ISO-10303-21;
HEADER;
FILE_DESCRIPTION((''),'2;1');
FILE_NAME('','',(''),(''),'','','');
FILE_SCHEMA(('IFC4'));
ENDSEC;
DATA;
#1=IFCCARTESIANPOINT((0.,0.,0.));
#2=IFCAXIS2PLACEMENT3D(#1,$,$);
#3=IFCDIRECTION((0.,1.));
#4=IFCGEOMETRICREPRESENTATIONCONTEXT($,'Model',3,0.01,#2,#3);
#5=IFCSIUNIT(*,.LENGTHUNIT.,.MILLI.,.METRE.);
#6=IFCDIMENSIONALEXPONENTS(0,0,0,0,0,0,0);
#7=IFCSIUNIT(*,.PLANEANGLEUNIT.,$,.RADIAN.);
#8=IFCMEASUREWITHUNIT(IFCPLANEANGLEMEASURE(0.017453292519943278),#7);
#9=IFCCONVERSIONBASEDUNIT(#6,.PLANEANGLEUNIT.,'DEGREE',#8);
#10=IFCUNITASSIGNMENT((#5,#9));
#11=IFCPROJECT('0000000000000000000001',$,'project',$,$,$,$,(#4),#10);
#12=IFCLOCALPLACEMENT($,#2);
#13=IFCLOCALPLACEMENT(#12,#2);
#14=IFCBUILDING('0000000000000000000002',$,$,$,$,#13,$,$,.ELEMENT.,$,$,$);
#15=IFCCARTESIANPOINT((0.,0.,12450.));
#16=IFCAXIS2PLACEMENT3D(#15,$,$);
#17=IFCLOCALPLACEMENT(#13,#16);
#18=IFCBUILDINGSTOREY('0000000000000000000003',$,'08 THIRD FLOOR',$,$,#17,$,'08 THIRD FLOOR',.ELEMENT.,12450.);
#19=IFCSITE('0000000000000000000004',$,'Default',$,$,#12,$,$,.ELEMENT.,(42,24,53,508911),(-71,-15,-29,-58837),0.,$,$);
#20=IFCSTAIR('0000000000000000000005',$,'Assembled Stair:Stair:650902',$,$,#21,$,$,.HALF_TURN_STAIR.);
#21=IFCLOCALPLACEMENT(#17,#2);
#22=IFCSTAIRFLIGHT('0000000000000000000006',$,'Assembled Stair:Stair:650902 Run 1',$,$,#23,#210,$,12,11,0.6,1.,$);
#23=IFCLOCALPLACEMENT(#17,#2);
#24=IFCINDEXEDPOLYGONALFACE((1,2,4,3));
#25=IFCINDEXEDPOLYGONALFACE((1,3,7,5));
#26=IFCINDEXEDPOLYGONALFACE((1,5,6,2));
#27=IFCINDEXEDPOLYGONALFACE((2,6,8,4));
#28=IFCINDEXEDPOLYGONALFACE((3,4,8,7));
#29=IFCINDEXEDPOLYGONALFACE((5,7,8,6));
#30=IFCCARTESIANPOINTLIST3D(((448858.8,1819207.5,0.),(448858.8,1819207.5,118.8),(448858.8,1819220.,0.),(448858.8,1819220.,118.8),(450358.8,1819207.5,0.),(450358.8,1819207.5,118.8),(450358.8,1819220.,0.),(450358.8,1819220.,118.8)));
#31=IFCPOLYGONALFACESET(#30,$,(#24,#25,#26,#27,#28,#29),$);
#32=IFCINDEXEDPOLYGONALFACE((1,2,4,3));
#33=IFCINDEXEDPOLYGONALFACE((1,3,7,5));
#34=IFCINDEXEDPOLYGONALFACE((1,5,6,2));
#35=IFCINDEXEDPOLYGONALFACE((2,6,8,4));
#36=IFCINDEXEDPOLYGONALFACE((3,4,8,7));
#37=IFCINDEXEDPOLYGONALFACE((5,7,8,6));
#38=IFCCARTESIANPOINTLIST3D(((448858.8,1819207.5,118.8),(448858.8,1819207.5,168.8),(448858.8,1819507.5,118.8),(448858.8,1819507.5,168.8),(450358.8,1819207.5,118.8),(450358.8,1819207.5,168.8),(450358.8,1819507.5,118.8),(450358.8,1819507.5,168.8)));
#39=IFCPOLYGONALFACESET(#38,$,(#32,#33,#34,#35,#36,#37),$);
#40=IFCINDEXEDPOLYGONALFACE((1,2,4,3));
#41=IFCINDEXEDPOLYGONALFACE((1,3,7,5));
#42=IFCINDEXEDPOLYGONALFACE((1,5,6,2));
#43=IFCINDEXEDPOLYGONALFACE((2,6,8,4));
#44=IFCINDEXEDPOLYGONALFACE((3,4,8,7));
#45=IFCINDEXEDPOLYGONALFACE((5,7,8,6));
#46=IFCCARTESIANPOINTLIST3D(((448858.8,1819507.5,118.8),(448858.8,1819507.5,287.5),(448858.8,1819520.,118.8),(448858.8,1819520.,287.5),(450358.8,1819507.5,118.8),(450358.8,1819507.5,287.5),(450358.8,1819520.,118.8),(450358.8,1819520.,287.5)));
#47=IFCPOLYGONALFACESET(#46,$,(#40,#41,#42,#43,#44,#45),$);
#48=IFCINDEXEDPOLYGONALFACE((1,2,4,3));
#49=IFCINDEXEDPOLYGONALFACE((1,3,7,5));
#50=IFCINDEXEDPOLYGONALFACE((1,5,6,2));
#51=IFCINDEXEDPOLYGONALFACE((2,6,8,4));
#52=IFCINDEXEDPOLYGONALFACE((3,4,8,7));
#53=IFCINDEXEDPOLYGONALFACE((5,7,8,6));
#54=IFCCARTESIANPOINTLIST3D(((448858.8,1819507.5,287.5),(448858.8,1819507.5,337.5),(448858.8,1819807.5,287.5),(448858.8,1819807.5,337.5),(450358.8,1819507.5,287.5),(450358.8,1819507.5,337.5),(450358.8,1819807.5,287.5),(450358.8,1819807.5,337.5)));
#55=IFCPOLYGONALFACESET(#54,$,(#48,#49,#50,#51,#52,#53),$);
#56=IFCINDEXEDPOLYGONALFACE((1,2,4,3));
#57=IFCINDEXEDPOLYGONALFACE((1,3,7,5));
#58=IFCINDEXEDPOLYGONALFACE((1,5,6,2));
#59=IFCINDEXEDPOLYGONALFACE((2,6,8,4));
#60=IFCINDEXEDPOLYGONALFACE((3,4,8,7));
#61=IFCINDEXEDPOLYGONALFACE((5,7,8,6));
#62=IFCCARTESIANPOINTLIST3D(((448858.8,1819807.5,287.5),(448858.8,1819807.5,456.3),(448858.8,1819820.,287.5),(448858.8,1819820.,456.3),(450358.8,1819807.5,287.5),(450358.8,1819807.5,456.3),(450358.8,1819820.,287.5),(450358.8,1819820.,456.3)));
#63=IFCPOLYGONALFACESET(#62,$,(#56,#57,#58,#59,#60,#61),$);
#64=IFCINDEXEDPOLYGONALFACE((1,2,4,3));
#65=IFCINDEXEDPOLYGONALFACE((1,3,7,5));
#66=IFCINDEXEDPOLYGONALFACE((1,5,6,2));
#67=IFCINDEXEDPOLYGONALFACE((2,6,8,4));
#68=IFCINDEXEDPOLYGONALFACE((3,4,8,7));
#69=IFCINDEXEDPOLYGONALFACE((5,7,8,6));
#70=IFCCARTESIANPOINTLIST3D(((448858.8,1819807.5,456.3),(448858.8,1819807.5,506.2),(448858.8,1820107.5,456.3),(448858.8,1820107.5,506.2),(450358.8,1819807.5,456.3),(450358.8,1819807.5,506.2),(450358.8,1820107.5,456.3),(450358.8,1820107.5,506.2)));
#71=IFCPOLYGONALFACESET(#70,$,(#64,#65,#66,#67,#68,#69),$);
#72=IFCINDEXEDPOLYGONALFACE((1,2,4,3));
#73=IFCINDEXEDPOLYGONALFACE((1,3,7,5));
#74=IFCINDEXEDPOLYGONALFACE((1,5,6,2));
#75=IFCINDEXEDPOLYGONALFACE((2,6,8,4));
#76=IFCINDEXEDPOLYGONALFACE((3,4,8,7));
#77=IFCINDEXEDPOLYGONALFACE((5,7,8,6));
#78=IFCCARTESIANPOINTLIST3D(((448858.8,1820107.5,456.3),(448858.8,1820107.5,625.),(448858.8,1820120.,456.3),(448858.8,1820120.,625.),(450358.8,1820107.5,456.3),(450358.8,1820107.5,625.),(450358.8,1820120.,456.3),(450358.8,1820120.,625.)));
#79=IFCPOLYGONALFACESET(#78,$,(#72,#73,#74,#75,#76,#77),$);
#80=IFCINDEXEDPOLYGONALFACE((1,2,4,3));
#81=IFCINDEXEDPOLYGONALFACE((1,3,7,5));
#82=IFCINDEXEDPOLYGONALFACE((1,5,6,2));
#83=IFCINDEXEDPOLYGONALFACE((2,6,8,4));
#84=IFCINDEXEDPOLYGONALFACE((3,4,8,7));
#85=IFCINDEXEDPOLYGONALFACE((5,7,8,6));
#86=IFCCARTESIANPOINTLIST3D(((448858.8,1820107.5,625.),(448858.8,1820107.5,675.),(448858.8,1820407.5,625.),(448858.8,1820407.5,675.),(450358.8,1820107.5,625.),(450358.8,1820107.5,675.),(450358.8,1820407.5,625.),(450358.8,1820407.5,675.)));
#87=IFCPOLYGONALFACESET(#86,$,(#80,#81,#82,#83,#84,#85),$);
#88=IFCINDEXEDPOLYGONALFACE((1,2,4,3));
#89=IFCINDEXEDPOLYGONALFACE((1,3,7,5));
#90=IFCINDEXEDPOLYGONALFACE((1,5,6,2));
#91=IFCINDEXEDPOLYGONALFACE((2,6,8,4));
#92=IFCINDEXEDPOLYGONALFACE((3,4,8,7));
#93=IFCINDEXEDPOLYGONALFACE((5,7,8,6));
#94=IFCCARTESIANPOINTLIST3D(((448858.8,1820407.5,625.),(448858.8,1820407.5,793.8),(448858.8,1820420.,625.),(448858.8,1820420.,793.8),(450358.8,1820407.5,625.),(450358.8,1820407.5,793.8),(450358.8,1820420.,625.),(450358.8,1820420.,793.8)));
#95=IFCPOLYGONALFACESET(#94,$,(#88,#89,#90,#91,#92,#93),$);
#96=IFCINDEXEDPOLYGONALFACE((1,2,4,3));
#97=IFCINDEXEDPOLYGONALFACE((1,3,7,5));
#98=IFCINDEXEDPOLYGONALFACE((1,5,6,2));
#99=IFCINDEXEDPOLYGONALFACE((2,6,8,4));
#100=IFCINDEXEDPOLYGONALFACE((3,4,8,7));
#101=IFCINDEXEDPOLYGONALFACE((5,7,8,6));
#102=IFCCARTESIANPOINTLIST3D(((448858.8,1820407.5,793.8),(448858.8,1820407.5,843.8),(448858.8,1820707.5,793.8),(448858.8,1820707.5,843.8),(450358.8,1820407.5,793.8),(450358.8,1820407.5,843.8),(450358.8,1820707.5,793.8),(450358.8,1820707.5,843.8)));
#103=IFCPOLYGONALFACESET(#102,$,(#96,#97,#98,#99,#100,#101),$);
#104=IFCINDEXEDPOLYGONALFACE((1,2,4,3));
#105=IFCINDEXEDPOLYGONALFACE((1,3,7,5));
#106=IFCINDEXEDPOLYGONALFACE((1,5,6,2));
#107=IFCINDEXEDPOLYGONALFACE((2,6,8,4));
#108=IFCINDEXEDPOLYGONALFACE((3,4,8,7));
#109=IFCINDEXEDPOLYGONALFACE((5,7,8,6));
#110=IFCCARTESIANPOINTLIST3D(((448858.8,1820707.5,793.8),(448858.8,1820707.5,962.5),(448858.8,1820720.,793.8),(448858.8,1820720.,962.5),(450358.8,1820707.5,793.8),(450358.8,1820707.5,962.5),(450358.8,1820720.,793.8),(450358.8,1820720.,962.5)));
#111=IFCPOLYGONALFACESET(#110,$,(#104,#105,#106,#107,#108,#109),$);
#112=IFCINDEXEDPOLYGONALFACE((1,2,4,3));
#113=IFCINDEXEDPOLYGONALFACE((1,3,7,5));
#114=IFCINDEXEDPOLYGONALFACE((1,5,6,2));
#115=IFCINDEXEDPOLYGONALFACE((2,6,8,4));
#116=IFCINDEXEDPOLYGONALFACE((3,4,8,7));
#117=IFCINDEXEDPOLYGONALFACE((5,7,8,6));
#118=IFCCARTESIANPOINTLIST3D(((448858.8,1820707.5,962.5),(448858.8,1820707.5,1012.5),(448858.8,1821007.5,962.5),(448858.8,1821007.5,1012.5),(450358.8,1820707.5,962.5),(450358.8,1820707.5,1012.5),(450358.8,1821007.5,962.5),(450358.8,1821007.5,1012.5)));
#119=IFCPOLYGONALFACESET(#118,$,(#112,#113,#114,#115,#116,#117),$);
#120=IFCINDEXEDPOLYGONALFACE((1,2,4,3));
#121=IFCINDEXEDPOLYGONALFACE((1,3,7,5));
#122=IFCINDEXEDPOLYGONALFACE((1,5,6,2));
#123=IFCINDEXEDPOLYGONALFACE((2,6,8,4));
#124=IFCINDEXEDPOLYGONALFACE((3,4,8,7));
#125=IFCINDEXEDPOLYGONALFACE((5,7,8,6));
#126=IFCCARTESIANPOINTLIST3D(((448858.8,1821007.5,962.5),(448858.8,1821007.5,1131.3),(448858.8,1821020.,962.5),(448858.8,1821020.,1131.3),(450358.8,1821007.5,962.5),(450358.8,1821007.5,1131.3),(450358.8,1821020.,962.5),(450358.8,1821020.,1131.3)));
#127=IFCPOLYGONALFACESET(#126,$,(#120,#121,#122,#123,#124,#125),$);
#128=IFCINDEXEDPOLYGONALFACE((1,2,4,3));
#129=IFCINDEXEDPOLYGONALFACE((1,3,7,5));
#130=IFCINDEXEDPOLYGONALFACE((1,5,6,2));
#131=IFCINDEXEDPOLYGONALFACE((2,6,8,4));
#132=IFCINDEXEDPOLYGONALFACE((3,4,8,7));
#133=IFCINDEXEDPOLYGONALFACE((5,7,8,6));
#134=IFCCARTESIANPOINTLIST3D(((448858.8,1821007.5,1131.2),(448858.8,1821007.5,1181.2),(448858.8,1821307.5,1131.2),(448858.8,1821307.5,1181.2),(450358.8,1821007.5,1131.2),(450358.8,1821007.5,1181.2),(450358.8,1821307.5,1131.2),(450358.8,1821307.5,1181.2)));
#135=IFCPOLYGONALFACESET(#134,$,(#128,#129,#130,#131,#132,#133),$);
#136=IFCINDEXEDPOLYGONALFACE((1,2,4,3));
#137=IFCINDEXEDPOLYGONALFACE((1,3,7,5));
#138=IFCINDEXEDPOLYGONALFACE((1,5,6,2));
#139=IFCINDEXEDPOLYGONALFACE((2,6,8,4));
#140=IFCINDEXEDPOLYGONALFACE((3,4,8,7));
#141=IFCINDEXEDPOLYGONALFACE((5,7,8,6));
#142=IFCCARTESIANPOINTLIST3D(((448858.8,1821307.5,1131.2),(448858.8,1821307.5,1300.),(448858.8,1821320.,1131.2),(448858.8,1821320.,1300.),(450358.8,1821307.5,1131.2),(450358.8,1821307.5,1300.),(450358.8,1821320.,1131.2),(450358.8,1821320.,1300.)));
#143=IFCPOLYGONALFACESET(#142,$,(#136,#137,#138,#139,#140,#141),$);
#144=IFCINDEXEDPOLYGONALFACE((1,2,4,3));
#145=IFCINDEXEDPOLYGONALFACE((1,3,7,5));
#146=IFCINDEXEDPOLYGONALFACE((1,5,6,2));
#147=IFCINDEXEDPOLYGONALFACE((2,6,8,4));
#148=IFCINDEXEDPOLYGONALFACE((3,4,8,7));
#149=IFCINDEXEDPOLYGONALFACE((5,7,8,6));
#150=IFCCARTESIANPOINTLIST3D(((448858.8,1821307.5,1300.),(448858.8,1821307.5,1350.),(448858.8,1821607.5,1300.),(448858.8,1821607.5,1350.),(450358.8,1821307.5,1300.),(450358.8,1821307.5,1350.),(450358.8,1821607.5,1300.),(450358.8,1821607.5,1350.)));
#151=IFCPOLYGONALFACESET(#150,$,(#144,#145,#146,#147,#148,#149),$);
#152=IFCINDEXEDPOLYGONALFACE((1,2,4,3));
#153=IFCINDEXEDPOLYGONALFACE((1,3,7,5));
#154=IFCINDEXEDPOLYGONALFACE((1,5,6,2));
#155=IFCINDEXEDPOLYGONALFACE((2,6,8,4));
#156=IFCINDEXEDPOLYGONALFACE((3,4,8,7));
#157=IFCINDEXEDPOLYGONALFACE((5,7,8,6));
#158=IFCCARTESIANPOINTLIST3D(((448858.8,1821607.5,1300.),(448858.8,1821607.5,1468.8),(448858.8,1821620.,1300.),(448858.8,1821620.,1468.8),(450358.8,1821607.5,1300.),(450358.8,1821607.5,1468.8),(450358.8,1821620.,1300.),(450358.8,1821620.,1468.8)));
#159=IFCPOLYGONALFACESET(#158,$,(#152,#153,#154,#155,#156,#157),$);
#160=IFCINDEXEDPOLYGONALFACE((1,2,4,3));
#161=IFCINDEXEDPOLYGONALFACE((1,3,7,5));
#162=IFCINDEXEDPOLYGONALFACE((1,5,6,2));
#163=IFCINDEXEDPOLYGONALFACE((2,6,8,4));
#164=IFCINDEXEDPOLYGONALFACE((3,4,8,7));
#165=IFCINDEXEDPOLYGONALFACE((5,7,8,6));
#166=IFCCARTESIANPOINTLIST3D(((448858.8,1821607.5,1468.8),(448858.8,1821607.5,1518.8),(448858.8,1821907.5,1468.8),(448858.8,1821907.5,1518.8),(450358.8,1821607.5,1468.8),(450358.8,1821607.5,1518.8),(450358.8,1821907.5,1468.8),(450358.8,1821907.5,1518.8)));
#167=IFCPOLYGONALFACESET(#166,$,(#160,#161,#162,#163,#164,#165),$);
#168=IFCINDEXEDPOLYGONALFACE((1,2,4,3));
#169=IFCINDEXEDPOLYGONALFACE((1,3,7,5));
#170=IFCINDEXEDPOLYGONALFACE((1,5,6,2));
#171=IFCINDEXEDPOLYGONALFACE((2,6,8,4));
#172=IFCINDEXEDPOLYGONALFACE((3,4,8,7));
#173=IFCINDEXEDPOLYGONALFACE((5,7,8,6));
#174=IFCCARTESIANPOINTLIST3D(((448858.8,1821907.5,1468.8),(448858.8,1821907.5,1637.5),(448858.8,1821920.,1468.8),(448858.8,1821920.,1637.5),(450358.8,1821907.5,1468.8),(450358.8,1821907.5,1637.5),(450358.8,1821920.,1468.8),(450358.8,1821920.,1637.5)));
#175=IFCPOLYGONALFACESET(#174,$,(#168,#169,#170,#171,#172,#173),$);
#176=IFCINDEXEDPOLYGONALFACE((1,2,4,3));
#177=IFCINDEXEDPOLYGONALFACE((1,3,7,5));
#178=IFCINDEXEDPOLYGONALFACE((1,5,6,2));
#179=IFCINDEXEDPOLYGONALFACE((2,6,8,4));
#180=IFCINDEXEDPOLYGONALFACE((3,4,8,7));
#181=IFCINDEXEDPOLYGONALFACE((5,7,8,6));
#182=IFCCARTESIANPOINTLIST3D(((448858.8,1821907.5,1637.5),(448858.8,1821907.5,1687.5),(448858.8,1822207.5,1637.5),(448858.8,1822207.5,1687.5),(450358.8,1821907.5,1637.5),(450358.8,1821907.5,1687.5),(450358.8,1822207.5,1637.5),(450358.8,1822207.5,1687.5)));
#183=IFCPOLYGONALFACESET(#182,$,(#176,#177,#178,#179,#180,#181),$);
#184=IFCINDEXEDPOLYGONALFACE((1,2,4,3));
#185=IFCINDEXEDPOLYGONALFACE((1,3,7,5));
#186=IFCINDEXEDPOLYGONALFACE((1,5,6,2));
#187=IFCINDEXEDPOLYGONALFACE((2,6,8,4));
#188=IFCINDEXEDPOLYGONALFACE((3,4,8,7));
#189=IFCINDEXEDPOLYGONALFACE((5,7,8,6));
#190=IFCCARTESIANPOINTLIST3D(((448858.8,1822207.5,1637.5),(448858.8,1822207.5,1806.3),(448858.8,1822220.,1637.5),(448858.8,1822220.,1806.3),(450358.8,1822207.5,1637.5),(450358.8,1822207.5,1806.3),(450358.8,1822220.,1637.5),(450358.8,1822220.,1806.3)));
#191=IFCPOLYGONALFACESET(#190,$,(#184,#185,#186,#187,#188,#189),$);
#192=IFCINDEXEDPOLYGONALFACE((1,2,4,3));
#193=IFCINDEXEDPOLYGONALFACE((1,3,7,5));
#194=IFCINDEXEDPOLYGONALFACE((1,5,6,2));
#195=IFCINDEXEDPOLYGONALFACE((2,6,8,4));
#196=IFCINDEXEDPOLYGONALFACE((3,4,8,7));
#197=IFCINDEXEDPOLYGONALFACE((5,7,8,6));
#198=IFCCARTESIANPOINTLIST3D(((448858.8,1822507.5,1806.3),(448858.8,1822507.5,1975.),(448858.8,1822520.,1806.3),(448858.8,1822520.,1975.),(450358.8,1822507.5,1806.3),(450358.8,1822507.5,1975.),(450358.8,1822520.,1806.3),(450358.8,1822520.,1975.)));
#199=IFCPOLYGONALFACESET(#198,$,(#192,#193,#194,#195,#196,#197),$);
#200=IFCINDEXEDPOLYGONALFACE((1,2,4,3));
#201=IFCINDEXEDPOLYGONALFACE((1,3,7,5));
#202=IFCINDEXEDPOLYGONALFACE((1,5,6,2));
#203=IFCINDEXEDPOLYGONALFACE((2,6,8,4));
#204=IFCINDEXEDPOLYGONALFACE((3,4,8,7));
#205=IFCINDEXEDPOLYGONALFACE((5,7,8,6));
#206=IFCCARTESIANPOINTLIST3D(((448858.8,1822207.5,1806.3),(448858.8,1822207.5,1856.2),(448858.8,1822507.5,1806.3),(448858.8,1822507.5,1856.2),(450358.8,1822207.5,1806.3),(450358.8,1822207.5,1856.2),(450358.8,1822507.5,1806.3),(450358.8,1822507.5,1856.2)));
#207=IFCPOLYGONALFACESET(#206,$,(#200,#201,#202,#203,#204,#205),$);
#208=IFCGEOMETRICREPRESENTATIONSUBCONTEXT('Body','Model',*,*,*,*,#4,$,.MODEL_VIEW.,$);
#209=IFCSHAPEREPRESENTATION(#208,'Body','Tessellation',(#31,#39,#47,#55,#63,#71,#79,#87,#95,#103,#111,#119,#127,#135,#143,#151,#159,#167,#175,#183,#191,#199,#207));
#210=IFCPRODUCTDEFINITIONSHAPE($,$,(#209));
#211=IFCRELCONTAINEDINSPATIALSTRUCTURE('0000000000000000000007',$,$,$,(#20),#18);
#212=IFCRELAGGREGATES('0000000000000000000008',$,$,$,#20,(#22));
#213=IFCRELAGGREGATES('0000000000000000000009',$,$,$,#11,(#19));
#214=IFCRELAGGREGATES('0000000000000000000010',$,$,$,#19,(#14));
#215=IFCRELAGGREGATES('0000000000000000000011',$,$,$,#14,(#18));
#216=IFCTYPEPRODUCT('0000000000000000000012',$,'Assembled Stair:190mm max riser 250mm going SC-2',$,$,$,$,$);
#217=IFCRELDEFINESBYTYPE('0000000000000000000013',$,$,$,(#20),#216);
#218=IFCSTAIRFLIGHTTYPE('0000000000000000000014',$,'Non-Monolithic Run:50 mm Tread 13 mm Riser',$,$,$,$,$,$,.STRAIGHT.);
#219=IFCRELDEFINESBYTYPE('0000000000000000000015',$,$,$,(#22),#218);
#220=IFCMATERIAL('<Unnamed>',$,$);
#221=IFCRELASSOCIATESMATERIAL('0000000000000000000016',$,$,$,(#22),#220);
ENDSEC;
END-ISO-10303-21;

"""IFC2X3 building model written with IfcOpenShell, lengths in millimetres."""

from ifc_helpers import new_model, entity, si_unit, converted_unit, direction, frame, frame_2d, origin, origin_2d_with_axis, place, context, subcontext, project, spatial, rectangle, extrude, material, type_object, element, aggregate, save


model = new_model("IFC2X3")

# Units and contexts
model_context = context("Model", 3, precision=0.01, world=origin(), true_north=direction((0.0, 1.0)))
body_context = subcontext(model_context, "Body", "Model", "MODEL_VIEW")
ifc_project = project(units=[si_unit("LENGTHUNIT", "METRE", prefix="MILLI"), converted_unit("PLANEANGLEUNIT", "DEGREE", entity("IfcPlaneAngleMeasure", 0.017453292519943278), si_unit("PLANEANGLEUNIT", "RADIAN"), dimensions=[0, 0, 0, 0, 0, 0, 0])], contexts=[model_context])

# Site, building, storey
site_placement = place(None, origin())
site = spatial("IfcSite", under=ifc_project, at=site_placement, Name="Default", CompositionType="ELEMENT", RefLatitude=(42, 24, 53, 508911), RefLongitude=(-71, -15, -29, -58837), RefElevation=0.0)
building_placement = place(site_placement, origin())
building = spatial("IfcBuilding", under=site, at=building_placement, CompositionType="ELEMENT")
storey_placement = place(building_placement, frame((0.0, 0.0, 12450.0)))
storey = spatial("IfcBuildingStorey", under=building, at=storey_placement, Name="08 THIRD FLOOR", LongName="08 THIRD FLOOR", CompositionType="ELEMENT", Elevation=12450.0)

# Stair
ifc_material_1 = material(Name="<Unnamed>")
type_product_1 = type_object("IfcTypeProduct", Name="Assembled Stair:190mm max riser 250mm going SC-2")
stair_1_placement = place(storey_placement, origin())
stair_1 = element("IfcStair", 1, at=stair_1_placement, inside=storey, type_object=type_product_1, Name="Assembled Stair:Stair:650902", ShapeType="HALF_TURN_STAIR")

# Stair flight
stair_flight_type = type_object("IfcStairFlightType", Name="Non-Monolithic Run:50 mm Tread 13 mm Riser", PredefinedType="STRAIGHT")
stair_flight_1_placement = place(stair_1_placement, origin())
stair_flight_1 = element("IfcStairFlight", 2, at=stair_flight_1_placement, type_object=stair_flight_type, material=ifc_material_1, Name="Assembled Stair:Stair:650902 Run 1", NumberOfRiser=12, NumberOfTreads=11, RiserHeight=0.6, TreadLength=1.0, context=body_context, shape_type="SweptSolid", body=[
    extrude(rectangle(XDim=1500.0, YDim=12.5, at=origin_2d_with_axis()), frame((449608.8, 1819213.8, 0.0), z_axis=(0.0, 0.0, 1.0), x_axis=(-1.0, 0.0, 0.0)), (0.0, 0.0, 1.0), 118.8),
    extrude(rectangle(XDim=300.0, YDim=1500.0, at=frame_2d((0.0, 0.0), x_axis=(1.0, 0.0))), frame((449608.8, 1819357.5, 118.8), z_axis=(0.0, 0.0, 1.0), x_axis=(0.0, -1.0, 0.0)), (0.0, 0.0, 1.0), 50.0),
    extrude(rectangle(XDim=1500.0, YDim=12.5, at=origin_2d_with_axis()), frame((449608.8, 1819513.8, 118.7), z_axis=(0.0, 0.0, 1.0), x_axis=(-1.0, 0.0, 0.0)), (0.0, 0.0, 1.0), 168.8),
    extrude(rectangle(XDim=300.0, YDim=1500.0, at=origin_2d_with_axis()), frame((449608.8, 1819657.5, 287.5), z_axis=(0.0, 0.0, 1.0), x_axis=(0.0, -1.0, 0.0)), (0.0, 0.0, 1.0), 50.0),
    extrude(rectangle(XDim=1500.0, YDim=12.5, at=origin_2d_with_axis()), frame((449608.8, 1819813.8, 287.5), z_axis=(0.0, 0.0, 1.0), x_axis=(-1.0, 0.0, 0.0)), (0.0, 0.0, 1.0), 168.8),
    extrude(rectangle(XDim=300.0, YDim=1500.0, at=origin_2d_with_axis()), frame((449608.8, 1819957.5, 456.3), z_axis=(0.0, 0.0, 1.0), x_axis=(0.0, -1.0, 0.0)), (0.0, 0.0, 1.0), 50.0),
    extrude(rectangle(XDim=1500.0, YDim=12.5, at=origin_2d_with_axis()), frame((449608.8, 1820113.8, 456.3), z_axis=(0.0, 0.0, 1.0), x_axis=(-1.0, 0.0, 0.0)), (0.0, 0.0, 1.0), 168.8),
    extrude(rectangle(XDim=300.0, YDim=1500.0, at=origin_2d_with_axis()), frame((449608.8, 1820257.5, 625.0), z_axis=(0.0, 0.0, 1.0), x_axis=(0.0, -1.0, 0.0)), (0.0, 0.0, 1.0), 50.0),
    extrude(rectangle(XDim=1500.0, YDim=12.5, at=origin_2d_with_axis()), frame((449608.8, 1820413.8, 625.0), z_axis=(0.0, 0.0, 1.0), x_axis=(-1.0, 0.0, 0.0)), (0.0, 0.0, 1.0), 168.8),
    extrude(rectangle(XDim=300.0, YDim=1500.0, at=origin_2d_with_axis()), frame((449608.8, 1820557.5, 793.8), z_axis=(0.0, 0.0, 1.0), x_axis=(0.0, -1.0, 0.0)), (0.0, 0.0, 1.0), 50.0),
    extrude(rectangle(XDim=1500.0, YDim=12.5, at=origin_2d_with_axis()), frame((449608.8, 1820713.8, 793.7), z_axis=(0.0, 0.0, 1.0), x_axis=(-1.0, 0.0, 0.0)), (0.0, 0.0, 1.0), 168.8),
    extrude(rectangle(XDim=300.0, YDim=1500.0, at=origin_2d_with_axis()), frame((449608.8, 1820857.5, 962.5), z_axis=(0.0, 0.0, 1.0), x_axis=(0.0, -1.0, 0.0)), (0.0, 0.0, 1.0), 50.0),
    extrude(rectangle(XDim=1500.0, YDim=12.5, at=origin_2d_with_axis()), frame((449608.8, 1821013.8, 962.5), z_axis=(0.0, 0.0, 1.0), x_axis=(-1.0, 0.0, 0.0)), (0.0, 0.0, 1.0), 168.8),
    extrude(rectangle(XDim=300.0, YDim=1500.0, at=origin_2d_with_axis()), frame((449608.8, 1821157.5, 1131.3), z_axis=(0.0, 0.0, 1.0), x_axis=(0.0, -1.0, 0.0)), (0.0, 0.0, 1.0), 50.0),
    extrude(rectangle(XDim=1500.0, YDim=12.5, at=origin_2d_with_axis()), frame((449608.8, 1821313.8, 1131.3), z_axis=(0.0, 0.0, 1.0), x_axis=(-1.0, 0.0, 0.0)), (0.0, 0.0, 1.0), 168.8),
    extrude(rectangle(XDim=300.0, YDim=1500.0, at=origin_2d_with_axis()), frame((449608.8, 1821457.5, 1300.0), z_axis=(0.0, 0.0, 1.0), x_axis=(0.0, -1.0, 0.0)), (0.0, 0.0, 1.0), 50.0),
    extrude(rectangle(XDim=1500.0, YDim=12.5, at=origin_2d_with_axis()), frame((449608.8, 1821613.8, 1300.0), z_axis=(0.0, 0.0, 1.0), x_axis=(-1.0, 0.0, 0.0)), (0.0, 0.0, 1.0), 168.8),
    extrude(rectangle(XDim=300.0, YDim=1500.0, at=origin_2d_with_axis()), frame((449608.8, 1821757.5, 1468.7), z_axis=(0.0, 0.0, 1.0), x_axis=(0.0, -1.0, 0.0)), (0.0, 0.0, 1.0), 50.0),
    extrude(rectangle(XDim=1500.0, YDim=12.5, at=origin_2d_with_axis()), frame((449608.8, 1821913.8, 1468.7), z_axis=(0.0, 0.0, 1.0), x_axis=(-1.0, 0.0, 0.0)), (0.0, 0.0, 1.0), 168.8),
    extrude(rectangle(XDim=300.0, YDim=1500.0, at=origin_2d_with_axis()), frame((449608.8, 1822057.5, 1637.5), z_axis=(0.0, 0.0, 1.0), x_axis=(0.0, -1.0, 0.0)), (0.0, 0.0, 1.0), 50.0),
    extrude(rectangle(XDim=1500.0, YDim=12.5, at=origin_2d_with_axis()), frame((449608.8, 1822213.8, 1637.5), z_axis=(0.0, 0.0, 1.0), x_axis=(-1.0, 0.0, 0.0)), (0.0, 0.0, 1.0), 168.8),
    extrude(rectangle(XDim=1500.0, YDim=12.5, at=origin_2d_with_axis()), frame((449608.8, 1822513.8, 1806.3), z_axis=(0.0, 0.0, 1.0), x_axis=(-1.0, 0.0, 0.0)), (0.0, 0.0, 1.0), 168.7),
    extrude(rectangle(XDim=300.0, YDim=1500.0, at=origin_2d_with_axis()), frame((449608.8, 1822357.5, 1806.3), z_axis=(0.0, 0.0, 1.0), x_axis=(0.0, -1.0, 0.0)), (0.0, 0.0, 1.0), 50.0),
])

aggregate(stair_1, [stair_flight_1])

save(model, "model.ifc")
